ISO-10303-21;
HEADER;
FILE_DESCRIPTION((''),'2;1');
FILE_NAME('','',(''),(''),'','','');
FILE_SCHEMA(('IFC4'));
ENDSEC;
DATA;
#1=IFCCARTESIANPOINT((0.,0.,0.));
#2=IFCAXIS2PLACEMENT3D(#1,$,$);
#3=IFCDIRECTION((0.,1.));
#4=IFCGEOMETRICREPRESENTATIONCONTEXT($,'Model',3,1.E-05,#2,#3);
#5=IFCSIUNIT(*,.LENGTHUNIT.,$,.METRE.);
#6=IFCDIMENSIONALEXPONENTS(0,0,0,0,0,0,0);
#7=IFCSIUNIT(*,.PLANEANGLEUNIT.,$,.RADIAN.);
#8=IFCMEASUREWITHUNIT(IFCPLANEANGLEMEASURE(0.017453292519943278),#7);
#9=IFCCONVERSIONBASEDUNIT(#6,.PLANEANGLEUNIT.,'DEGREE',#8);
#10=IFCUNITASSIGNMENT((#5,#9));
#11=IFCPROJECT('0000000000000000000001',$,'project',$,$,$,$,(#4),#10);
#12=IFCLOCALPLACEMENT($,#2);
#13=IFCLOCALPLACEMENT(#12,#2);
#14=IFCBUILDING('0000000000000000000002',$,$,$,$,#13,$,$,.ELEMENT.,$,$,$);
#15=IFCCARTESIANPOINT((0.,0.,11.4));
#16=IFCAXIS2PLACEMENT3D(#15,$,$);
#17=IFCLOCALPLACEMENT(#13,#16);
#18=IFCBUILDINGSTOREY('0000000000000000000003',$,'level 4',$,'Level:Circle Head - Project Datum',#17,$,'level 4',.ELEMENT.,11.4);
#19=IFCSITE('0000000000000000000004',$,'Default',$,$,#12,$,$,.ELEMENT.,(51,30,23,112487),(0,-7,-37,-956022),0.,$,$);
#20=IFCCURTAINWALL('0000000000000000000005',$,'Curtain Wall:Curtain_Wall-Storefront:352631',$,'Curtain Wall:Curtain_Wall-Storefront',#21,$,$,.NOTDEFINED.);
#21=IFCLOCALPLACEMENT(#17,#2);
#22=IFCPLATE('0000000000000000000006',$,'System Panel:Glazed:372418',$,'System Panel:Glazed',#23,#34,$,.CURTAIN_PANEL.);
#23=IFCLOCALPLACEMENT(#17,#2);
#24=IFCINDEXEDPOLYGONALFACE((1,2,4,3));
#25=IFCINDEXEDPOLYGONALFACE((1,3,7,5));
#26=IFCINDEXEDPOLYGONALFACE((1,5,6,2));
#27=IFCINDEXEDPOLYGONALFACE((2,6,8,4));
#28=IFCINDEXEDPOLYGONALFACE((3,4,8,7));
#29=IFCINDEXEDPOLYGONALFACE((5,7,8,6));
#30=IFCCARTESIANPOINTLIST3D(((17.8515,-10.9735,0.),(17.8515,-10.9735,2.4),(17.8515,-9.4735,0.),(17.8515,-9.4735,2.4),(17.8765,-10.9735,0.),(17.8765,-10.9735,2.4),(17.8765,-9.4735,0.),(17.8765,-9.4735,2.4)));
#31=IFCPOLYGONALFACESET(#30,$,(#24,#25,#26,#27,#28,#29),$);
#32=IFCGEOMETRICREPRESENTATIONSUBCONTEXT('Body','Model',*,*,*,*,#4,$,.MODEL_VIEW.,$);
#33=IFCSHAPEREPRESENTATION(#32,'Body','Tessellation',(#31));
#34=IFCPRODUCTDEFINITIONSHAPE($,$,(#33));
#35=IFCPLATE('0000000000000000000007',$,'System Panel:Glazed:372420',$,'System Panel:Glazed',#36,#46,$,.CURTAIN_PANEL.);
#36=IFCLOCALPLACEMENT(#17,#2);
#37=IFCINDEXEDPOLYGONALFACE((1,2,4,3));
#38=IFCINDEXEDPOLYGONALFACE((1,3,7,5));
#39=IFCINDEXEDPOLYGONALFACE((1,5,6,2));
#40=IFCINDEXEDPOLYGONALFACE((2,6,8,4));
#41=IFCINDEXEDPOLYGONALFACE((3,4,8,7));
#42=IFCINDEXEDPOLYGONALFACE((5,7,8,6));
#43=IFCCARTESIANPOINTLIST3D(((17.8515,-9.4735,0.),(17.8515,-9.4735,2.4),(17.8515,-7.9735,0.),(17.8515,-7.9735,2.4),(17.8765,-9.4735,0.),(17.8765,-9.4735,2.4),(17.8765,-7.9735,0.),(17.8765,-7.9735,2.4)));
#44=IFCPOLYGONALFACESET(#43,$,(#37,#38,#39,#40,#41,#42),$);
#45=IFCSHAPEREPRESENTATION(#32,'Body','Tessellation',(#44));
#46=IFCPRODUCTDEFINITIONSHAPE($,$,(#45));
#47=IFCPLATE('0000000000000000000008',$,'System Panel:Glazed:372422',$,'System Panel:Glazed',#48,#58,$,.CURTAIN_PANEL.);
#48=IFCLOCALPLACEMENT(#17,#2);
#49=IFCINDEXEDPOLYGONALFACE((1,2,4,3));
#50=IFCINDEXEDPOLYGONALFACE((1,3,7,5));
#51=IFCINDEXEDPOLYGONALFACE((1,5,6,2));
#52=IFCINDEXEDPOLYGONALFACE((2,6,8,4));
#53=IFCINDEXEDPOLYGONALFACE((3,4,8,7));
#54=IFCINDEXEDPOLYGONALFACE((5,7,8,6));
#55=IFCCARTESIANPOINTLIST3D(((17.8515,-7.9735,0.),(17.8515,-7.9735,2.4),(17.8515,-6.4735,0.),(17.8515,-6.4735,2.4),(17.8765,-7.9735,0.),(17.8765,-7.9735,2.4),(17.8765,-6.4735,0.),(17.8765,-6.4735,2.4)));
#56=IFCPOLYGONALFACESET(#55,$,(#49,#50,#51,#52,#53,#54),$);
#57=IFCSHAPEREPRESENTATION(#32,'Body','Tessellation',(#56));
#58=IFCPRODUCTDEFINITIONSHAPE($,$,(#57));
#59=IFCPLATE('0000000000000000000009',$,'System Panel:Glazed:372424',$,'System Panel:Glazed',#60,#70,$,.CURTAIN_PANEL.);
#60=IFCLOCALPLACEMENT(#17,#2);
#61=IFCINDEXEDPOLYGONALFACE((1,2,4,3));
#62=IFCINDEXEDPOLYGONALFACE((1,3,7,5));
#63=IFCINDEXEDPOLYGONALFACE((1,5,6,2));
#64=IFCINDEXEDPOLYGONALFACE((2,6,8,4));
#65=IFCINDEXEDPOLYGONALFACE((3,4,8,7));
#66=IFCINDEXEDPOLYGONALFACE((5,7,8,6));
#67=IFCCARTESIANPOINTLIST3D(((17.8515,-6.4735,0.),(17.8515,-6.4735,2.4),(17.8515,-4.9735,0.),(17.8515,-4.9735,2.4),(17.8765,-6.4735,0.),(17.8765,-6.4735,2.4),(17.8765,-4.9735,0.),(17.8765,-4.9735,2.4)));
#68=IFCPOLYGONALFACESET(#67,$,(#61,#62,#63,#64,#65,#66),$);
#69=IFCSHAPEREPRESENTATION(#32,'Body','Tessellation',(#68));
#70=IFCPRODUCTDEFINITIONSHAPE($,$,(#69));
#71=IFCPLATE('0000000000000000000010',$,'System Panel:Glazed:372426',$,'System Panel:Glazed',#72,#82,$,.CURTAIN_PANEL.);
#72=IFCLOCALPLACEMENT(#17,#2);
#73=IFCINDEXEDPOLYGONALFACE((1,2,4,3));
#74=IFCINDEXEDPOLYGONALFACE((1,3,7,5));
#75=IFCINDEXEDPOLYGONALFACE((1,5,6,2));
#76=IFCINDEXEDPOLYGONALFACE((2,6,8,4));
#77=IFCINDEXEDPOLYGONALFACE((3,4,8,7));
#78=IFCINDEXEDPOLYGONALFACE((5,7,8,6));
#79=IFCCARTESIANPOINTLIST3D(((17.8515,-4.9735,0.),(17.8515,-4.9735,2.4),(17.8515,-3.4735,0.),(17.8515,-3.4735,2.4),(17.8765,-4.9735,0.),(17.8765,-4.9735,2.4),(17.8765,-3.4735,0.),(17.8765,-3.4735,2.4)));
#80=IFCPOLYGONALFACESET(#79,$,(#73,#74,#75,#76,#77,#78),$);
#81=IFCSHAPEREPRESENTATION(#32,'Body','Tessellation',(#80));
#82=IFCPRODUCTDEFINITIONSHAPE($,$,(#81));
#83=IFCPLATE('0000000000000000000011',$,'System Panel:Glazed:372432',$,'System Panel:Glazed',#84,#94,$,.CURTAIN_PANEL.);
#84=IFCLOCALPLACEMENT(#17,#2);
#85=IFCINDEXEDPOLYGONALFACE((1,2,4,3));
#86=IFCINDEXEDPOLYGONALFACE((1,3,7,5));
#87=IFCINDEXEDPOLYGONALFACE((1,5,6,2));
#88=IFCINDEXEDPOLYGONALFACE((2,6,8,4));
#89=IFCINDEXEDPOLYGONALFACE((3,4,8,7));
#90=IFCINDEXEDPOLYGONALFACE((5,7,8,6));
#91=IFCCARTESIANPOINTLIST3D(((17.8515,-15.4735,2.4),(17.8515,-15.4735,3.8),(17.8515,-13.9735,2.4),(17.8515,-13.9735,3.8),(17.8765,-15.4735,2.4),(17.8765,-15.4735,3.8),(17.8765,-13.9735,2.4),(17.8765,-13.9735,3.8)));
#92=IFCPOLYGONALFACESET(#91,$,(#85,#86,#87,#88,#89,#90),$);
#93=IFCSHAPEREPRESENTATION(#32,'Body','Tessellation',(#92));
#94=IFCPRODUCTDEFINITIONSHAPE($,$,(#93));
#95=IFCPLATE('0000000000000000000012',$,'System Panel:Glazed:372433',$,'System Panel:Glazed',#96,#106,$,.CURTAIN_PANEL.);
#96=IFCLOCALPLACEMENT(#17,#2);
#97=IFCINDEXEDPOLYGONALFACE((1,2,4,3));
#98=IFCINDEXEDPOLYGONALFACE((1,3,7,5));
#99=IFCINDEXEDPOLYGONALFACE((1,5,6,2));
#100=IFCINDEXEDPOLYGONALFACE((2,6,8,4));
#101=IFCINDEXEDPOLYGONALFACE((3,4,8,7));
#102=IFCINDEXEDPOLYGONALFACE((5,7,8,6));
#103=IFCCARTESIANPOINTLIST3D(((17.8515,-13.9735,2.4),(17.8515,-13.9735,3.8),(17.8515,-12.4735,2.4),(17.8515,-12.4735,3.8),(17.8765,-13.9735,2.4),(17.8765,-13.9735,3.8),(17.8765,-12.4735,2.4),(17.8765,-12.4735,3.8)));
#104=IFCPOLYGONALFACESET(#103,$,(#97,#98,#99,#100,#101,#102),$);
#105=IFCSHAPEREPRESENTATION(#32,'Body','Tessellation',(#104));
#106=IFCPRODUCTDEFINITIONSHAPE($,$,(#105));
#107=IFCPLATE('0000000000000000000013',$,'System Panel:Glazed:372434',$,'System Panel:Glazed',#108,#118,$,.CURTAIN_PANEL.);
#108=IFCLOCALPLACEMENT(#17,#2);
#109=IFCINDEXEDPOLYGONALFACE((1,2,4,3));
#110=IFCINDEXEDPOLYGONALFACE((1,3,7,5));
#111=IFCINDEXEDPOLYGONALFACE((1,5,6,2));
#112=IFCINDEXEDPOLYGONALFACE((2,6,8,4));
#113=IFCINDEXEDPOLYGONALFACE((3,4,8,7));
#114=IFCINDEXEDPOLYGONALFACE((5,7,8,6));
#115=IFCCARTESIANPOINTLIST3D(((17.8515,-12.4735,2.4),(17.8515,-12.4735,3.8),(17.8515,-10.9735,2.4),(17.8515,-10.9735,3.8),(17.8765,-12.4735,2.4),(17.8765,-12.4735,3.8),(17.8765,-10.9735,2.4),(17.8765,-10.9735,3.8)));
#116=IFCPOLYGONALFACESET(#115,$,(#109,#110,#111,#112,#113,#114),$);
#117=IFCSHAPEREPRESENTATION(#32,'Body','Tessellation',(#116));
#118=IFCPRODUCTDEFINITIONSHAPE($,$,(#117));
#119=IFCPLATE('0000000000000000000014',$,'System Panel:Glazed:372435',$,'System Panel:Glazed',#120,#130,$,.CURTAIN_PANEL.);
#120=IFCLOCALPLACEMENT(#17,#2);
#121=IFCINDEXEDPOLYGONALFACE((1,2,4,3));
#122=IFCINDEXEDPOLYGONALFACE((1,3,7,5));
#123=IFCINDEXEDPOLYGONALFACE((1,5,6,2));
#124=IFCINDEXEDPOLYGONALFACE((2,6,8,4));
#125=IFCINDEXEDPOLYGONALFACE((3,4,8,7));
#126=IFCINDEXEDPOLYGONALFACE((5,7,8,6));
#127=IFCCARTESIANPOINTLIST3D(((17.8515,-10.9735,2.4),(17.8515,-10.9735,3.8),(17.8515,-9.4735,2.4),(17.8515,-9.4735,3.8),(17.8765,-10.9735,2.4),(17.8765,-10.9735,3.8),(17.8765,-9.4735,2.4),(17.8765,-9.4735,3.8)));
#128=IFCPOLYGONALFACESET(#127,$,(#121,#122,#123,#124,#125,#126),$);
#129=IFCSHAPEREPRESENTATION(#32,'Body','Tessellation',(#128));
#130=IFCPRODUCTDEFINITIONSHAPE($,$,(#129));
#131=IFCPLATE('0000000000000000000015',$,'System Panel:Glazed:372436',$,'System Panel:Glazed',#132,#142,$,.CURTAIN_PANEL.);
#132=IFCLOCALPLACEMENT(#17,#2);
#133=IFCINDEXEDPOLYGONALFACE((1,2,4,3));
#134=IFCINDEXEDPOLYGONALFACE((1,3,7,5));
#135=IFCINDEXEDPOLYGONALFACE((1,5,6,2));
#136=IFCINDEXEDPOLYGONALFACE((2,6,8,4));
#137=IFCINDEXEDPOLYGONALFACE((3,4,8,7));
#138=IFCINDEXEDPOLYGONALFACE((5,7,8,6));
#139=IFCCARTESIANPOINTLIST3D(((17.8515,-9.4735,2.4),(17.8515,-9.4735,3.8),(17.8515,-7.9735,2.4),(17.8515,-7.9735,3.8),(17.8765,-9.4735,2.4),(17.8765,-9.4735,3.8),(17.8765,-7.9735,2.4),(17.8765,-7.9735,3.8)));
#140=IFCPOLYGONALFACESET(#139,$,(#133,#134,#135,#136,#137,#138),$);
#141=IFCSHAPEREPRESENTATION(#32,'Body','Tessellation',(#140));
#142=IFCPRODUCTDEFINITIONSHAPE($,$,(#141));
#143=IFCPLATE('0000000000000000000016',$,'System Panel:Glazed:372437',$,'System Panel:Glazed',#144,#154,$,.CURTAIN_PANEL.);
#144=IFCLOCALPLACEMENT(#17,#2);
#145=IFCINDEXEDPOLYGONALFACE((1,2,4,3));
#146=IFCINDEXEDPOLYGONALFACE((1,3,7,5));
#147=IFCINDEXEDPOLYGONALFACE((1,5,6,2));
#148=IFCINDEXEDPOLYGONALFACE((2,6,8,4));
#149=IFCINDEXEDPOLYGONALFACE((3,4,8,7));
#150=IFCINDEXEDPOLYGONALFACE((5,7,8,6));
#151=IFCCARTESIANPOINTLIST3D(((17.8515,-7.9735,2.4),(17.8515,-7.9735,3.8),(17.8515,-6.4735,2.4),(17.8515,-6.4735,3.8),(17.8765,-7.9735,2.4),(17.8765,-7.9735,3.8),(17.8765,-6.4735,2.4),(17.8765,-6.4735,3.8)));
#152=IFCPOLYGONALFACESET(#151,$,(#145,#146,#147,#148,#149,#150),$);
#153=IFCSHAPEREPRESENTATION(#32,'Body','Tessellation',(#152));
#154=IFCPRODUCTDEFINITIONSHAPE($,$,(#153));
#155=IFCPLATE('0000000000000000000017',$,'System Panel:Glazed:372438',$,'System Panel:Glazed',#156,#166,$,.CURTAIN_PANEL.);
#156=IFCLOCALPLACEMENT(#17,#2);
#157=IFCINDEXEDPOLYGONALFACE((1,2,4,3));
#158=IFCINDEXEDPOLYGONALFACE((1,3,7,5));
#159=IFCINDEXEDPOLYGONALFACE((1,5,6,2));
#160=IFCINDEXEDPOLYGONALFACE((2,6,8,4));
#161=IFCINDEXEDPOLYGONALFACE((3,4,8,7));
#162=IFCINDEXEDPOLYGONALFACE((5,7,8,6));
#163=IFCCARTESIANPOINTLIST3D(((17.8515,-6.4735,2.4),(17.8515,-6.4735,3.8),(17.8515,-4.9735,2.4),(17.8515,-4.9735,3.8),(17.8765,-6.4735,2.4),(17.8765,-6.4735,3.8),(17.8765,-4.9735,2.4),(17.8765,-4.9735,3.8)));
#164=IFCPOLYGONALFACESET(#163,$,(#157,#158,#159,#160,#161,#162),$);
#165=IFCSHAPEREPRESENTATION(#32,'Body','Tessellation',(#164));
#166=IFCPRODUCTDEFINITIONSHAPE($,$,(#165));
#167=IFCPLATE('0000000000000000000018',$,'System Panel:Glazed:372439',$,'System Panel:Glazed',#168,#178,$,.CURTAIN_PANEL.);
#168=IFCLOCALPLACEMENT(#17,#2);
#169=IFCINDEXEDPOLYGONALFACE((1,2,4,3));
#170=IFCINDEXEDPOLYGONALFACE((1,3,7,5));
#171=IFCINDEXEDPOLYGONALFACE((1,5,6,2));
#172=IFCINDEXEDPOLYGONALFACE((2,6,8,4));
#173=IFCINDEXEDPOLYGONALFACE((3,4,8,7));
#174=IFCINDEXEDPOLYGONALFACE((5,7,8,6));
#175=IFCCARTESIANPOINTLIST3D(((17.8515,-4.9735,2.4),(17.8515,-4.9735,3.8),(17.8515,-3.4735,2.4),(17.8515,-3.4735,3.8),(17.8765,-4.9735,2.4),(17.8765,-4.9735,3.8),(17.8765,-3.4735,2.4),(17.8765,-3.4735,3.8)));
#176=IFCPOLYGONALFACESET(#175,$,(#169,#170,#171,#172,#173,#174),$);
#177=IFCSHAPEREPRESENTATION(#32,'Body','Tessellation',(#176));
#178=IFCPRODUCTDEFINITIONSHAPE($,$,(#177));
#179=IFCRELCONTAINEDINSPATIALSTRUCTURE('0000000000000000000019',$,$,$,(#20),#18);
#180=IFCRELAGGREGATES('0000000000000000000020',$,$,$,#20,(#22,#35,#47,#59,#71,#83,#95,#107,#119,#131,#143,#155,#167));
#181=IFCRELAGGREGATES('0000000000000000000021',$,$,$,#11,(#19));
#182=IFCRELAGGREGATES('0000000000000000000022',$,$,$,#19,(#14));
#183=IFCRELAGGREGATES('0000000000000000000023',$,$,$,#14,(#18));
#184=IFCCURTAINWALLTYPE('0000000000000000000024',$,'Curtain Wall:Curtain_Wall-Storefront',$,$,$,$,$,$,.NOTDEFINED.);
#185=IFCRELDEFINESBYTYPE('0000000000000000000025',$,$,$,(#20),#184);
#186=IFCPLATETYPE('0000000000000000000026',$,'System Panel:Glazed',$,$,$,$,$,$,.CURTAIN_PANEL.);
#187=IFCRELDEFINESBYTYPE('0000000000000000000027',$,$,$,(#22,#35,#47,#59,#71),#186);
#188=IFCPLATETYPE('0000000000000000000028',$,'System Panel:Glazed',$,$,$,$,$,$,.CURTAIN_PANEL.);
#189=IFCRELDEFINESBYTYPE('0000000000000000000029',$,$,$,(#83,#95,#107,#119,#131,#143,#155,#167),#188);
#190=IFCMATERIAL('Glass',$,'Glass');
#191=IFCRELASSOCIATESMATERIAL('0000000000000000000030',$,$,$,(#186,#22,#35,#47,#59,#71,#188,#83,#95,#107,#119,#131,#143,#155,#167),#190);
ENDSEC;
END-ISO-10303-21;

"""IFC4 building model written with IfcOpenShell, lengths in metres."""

from ifc_helpers import new_model, entity, si_unit, converted_unit, direction, frame, origin, origin_2d_with_axis, place, context, subcontext, project, spatial, rectangle, extrude, source, transform, mapped, material, type_object, type_shapes, element, aggregate, save


model = new_model("IFC4")

# Units and contexts
model_context = context("Model", 3, precision=1e-05, world=origin(), true_north=direction((0.0, 1.0)))
body_context = subcontext(model_context, "Body", "Model", "MODEL_VIEW")
ifc_project = project(units=[si_unit("LENGTHUNIT", "METRE"), converted_unit("PLANEANGLEUNIT", "DEGREE", entity("IfcPlaneAngleMeasure", 0.017453292519943278), si_unit("PLANEANGLEUNIT", "RADIAN"), dimensions=[0, 0, 0, 0, 0, 0, 0])], contexts=[model_context])

# Site, building, storey
site_placement = place(None, origin())
site = spatial("IfcSite", under=ifc_project, at=site_placement, Name="Default", CompositionType="ELEMENT", RefLatitude=(51, 30, 23, 112487), RefLongitude=(0, -7, -37, -956022), RefElevation=0.0)
building_placement = place(site_placement, origin())
building = spatial("IfcBuilding", under=site, at=building_placement, CompositionType="ELEMENT")
storey_placement = place(building_placement, frame((0.0, 0.0, 11.4)))
storey = spatial("IfcBuildingStorey", under=building, at=storey_placement, Name="level 4", ObjectType="Level:Circle Head - Project Datum", LongName="level 4", CompositionType="ELEMENT", Elevation=11.4)

# Curtain wall, plates
curtain_wall_type = type_object("IfcCurtainWallType", Name="Curtain Wall:Curtain_Wall-Storefront", PredefinedType="NOTDEFINED")
curtain_wall_placement = place(storey_placement, frame((0.0, 0.0, -11.4)))
curtain_wall = element("IfcCurtainWall", 1, at=curtain_wall_placement, inside=storey, type_object=curtain_wall_type, Name="Curtain Wall:Curtain_Wall-Storefront:352631", ObjectType="Curtain Wall:Curtain_Wall-Storefront", PredefinedType="NOTDEFINED")
ifc_material_1 = material(Name="Glass", Category="Glass")
plate_type_1 = type_object("IfcPlateType", Name="System Panel:Glazed", PredefinedType="CURTAIN_PANEL", material=ifc_material_1)
shared_shape_1 = source(origin(), body_context, "Body", "SweptSolid", [
    extrude(rectangle(XDim=0.025, YDim=1.5, at=origin_2d_with_axis()), frame((0.75, 0.0125, 0.0), z_axis=(0.0, 0.0, 1.0), x_axis=(0.0, 1.0, 0.0)), (0.0, 0.0, 1.0), 2.4),
])
type_shapes(plate_type_1, [shared_shape_1])
plate_1_placement = place(curtain_wall_placement, frame((17.8765, -10.9735, 11.4), z_axis=(0.0, 0.0, 1.0), x_axis=(0.0, 1.0, 0.0)))
plate_1 = element("IfcPlate", 2, at=plate_1_placement, type_object=plate_type_1, material=ifc_material_1, Name="System Panel:Glazed:372418", ObjectType="System Panel:Glazed", PredefinedType="CURTAIN_PANEL", context=body_context, shape_type="MappedRepresentation", body=[
    mapped(shared_shape_1, transform((0.0, 0.0, 0.0), scale=1.0)),
])
plate_2_placement = place(curtain_wall_placement, frame((17.8765, -9.4735, 11.4), z_axis=(0.0, 0.0, 1.0), x_axis=(0.0, 1.0, 0.0)))
plate_2 = element("IfcPlate", 3, at=plate_2_placement, type_object=plate_type_1, material=ifc_material_1, Name="System Panel:Glazed:372420", ObjectType="System Panel:Glazed", PredefinedType="CURTAIN_PANEL", context=body_context, shape_type="MappedRepresentation", body=[
    mapped(shared_shape_1, transform((0.0, 0.0, 0.0), scale=1.0)),
])
plate_3_placement = place(curtain_wall_placement, frame((17.8765, -7.9735, 11.4), z_axis=(0.0, 0.0, 1.0), x_axis=(0.0, 1.0, 0.0)))
plate_3 = element("IfcPlate", 4, at=plate_3_placement, type_object=plate_type_1, material=ifc_material_1, Name="System Panel:Glazed:372422", ObjectType="System Panel:Glazed", PredefinedType="CURTAIN_PANEL", context=body_context, shape_type="MappedRepresentation", body=[
    mapped(shared_shape_1, transform((0.0, 0.0, 0.0), scale=1.0)),
])
plate_4_placement = place(curtain_wall_placement, frame((17.8765, -6.4735, 11.4), z_axis=(0.0, 0.0, 1.0), x_axis=(0.0, 1.0, 0.0)))
plate_4 = element("IfcPlate", 5, at=plate_4_placement, type_object=plate_type_1, material=ifc_material_1, Name="System Panel:Glazed:372424", ObjectType="System Panel:Glazed", PredefinedType="CURTAIN_PANEL", context=body_context, shape_type="MappedRepresentation", body=[
    mapped(shared_shape_1, transform((0.0, 0.0, 0.0), scale=1.0)),
])
plate_5_placement = place(curtain_wall_placement, frame((17.8765, -4.9735, 11.4), z_axis=(0.0, 0.0, 1.0), x_axis=(0.0, 1.0, 0.0)))
plate_5 = element("IfcPlate", 6, at=plate_5_placement, type_object=plate_type_1, material=ifc_material_1, Name="System Panel:Glazed:372426", ObjectType="System Panel:Glazed", PredefinedType="CURTAIN_PANEL", context=body_context, shape_type="MappedRepresentation", body=[
    mapped(shared_shape_1, transform((0.0, 0.0, 0.0), scale=1.0)),
])
plate_type_2 = type_object("IfcPlateType", Name="System Panel:Glazed", PredefinedType="CURTAIN_PANEL", material=ifc_material_1)
shared_shape_2 = source(origin(), body_context, "Body", "SweptSolid", [
    extrude(rectangle(XDim=0.025, YDim=1.5, at=origin_2d_with_axis()), frame((0.75, 0.0125, 0.0), z_axis=(0.0, 0.0, 1.0), x_axis=(0.0, 1.0, 0.0)), (0.0, 0.0, 1.0), 1.4),
])
type_shapes(plate_type_2, [shared_shape_2])
plate_6_placement = place(curtain_wall_placement, frame((17.8765, -15.4735, 13.8), z_axis=(0.0, 0.0, 1.0), x_axis=(0.0, 1.0, 0.0)))
plate_6 = element("IfcPlate", 7, at=plate_6_placement, type_object=plate_type_2, material=ifc_material_1, Name="System Panel:Glazed:372432", ObjectType="System Panel:Glazed", PredefinedType="CURTAIN_PANEL", context=body_context, shape_type="MappedRepresentation", body=[
    mapped(shared_shape_2, transform((0.0, 0.0, 0.0), scale=1.0)),
])
plate_7_placement = place(curtain_wall_placement, frame((17.8765, -13.9735, 13.8), z_axis=(0.0, 0.0, 1.0), x_axis=(0.0, 1.0, 0.0)))
plate_7 = element("IfcPlate", 8, at=plate_7_placement, type_object=plate_type_2, material=ifc_material_1, Name="System Panel:Glazed:372433", ObjectType="System Panel:Glazed", PredefinedType="CURTAIN_PANEL", context=body_context, shape_type="MappedRepresentation", body=[
    mapped(shared_shape_2, transform((0.0, 0.0, 0.0), scale=1.0)),
])
plate_8_placement = place(curtain_wall_placement, frame((17.8765, -12.4735, 13.8), z_axis=(0.0, 0.0, 1.0), x_axis=(0.0, 1.0, 0.0)))
plate_8 = element("IfcPlate", 9, at=plate_8_placement, type_object=plate_type_2, material=ifc_material_1, Name="System Panel:Glazed:372434", ObjectType="System Panel:Glazed", PredefinedType="CURTAIN_PANEL", context=body_context, shape_type="MappedRepresentation", body=[
    mapped(shared_shape_2, transform((0.0, 0.0, 0.0), scale=1.0)),
])
plate_9_placement = place(curtain_wall_placement, frame((17.8765, -10.9735, 13.8), z_axis=(0.0, 0.0, 1.0), x_axis=(0.0, 1.0, 0.0)))
plate_9 = element("IfcPlate", 10, at=plate_9_placement, type_object=plate_type_2, material=ifc_material_1, Name="System Panel:Glazed:372435", ObjectType="System Panel:Glazed", PredefinedType="CURTAIN_PANEL", context=body_context, shape_type="MappedRepresentation", body=[
    mapped(shared_shape_2, transform((0.0, 0.0, 0.0), scale=1.0)),
])
plate_10_placement = place(curtain_wall_placement, frame((17.8765, -9.4735, 13.8), z_axis=(0.0, 0.0, 1.0), x_axis=(0.0, 1.0, 0.0)))
plate_10 = element("IfcPlate", 11, at=plate_10_placement, type_object=plate_type_2, material=ifc_material_1, Name="System Panel:Glazed:372436", ObjectType="System Panel:Glazed", PredefinedType="CURTAIN_PANEL", context=body_context, shape_type="MappedRepresentation", body=[
    mapped(shared_shape_2, transform((0.0, 0.0, 0.0), scale=1.0)),
])
plate_11_placement = place(curtain_wall_placement, frame((17.8765, -7.9735, 13.8), z_axis=(0.0, 0.0, 1.0), x_axis=(0.0, 1.0, 0.0)))
plate_11 = element("IfcPlate", 12, at=plate_11_placement, type_object=plate_type_2, material=ifc_material_1, Name="System Panel:Glazed:372437", ObjectType="System Panel:Glazed", PredefinedType="CURTAIN_PANEL", context=body_context, shape_type="MappedRepresentation", body=[
    mapped(shared_shape_2, transform((0.0, 0.0, 0.0), scale=1.0)),
])
plate_12_placement = place(curtain_wall_placement, frame((17.8765, -6.4735, 13.8), z_axis=(0.0, 0.0, 1.0), x_axis=(0.0, 1.0, 0.0)))
plate_12 = element("IfcPlate", 13, at=plate_12_placement, type_object=plate_type_2, material=ifc_material_1, Name="System Panel:Glazed:372438", ObjectType="System Panel:Glazed", PredefinedType="CURTAIN_PANEL", context=body_context, shape_type="MappedRepresentation", body=[
    mapped(shared_shape_2, transform((0.0, 0.0, 0.0), scale=1.0)),
])
plate_13_placement = place(curtain_wall_placement, frame((17.8765, -4.9735, 13.8), z_axis=(0.0, 0.0, 1.0), x_axis=(0.0, 1.0, 0.0)))
plate_13 = element("IfcPlate", 14, at=plate_13_placement, type_object=plate_type_2, material=ifc_material_1, Name="System Panel:Glazed:372439", ObjectType="System Panel:Glazed", PredefinedType="CURTAIN_PANEL", context=body_context, shape_type="MappedRepresentation", body=[
    mapped(shared_shape_2, transform((0.0, 0.0, 0.0), scale=1.0)),
])
aggregate(curtain_wall, [plate_1, plate_2, plate_3, plate_4, plate_5, plate_6, plate_7, plate_8, plate_9, plate_10, plate_11, plate_12, plate_13])

save(model, "model.ifc")
